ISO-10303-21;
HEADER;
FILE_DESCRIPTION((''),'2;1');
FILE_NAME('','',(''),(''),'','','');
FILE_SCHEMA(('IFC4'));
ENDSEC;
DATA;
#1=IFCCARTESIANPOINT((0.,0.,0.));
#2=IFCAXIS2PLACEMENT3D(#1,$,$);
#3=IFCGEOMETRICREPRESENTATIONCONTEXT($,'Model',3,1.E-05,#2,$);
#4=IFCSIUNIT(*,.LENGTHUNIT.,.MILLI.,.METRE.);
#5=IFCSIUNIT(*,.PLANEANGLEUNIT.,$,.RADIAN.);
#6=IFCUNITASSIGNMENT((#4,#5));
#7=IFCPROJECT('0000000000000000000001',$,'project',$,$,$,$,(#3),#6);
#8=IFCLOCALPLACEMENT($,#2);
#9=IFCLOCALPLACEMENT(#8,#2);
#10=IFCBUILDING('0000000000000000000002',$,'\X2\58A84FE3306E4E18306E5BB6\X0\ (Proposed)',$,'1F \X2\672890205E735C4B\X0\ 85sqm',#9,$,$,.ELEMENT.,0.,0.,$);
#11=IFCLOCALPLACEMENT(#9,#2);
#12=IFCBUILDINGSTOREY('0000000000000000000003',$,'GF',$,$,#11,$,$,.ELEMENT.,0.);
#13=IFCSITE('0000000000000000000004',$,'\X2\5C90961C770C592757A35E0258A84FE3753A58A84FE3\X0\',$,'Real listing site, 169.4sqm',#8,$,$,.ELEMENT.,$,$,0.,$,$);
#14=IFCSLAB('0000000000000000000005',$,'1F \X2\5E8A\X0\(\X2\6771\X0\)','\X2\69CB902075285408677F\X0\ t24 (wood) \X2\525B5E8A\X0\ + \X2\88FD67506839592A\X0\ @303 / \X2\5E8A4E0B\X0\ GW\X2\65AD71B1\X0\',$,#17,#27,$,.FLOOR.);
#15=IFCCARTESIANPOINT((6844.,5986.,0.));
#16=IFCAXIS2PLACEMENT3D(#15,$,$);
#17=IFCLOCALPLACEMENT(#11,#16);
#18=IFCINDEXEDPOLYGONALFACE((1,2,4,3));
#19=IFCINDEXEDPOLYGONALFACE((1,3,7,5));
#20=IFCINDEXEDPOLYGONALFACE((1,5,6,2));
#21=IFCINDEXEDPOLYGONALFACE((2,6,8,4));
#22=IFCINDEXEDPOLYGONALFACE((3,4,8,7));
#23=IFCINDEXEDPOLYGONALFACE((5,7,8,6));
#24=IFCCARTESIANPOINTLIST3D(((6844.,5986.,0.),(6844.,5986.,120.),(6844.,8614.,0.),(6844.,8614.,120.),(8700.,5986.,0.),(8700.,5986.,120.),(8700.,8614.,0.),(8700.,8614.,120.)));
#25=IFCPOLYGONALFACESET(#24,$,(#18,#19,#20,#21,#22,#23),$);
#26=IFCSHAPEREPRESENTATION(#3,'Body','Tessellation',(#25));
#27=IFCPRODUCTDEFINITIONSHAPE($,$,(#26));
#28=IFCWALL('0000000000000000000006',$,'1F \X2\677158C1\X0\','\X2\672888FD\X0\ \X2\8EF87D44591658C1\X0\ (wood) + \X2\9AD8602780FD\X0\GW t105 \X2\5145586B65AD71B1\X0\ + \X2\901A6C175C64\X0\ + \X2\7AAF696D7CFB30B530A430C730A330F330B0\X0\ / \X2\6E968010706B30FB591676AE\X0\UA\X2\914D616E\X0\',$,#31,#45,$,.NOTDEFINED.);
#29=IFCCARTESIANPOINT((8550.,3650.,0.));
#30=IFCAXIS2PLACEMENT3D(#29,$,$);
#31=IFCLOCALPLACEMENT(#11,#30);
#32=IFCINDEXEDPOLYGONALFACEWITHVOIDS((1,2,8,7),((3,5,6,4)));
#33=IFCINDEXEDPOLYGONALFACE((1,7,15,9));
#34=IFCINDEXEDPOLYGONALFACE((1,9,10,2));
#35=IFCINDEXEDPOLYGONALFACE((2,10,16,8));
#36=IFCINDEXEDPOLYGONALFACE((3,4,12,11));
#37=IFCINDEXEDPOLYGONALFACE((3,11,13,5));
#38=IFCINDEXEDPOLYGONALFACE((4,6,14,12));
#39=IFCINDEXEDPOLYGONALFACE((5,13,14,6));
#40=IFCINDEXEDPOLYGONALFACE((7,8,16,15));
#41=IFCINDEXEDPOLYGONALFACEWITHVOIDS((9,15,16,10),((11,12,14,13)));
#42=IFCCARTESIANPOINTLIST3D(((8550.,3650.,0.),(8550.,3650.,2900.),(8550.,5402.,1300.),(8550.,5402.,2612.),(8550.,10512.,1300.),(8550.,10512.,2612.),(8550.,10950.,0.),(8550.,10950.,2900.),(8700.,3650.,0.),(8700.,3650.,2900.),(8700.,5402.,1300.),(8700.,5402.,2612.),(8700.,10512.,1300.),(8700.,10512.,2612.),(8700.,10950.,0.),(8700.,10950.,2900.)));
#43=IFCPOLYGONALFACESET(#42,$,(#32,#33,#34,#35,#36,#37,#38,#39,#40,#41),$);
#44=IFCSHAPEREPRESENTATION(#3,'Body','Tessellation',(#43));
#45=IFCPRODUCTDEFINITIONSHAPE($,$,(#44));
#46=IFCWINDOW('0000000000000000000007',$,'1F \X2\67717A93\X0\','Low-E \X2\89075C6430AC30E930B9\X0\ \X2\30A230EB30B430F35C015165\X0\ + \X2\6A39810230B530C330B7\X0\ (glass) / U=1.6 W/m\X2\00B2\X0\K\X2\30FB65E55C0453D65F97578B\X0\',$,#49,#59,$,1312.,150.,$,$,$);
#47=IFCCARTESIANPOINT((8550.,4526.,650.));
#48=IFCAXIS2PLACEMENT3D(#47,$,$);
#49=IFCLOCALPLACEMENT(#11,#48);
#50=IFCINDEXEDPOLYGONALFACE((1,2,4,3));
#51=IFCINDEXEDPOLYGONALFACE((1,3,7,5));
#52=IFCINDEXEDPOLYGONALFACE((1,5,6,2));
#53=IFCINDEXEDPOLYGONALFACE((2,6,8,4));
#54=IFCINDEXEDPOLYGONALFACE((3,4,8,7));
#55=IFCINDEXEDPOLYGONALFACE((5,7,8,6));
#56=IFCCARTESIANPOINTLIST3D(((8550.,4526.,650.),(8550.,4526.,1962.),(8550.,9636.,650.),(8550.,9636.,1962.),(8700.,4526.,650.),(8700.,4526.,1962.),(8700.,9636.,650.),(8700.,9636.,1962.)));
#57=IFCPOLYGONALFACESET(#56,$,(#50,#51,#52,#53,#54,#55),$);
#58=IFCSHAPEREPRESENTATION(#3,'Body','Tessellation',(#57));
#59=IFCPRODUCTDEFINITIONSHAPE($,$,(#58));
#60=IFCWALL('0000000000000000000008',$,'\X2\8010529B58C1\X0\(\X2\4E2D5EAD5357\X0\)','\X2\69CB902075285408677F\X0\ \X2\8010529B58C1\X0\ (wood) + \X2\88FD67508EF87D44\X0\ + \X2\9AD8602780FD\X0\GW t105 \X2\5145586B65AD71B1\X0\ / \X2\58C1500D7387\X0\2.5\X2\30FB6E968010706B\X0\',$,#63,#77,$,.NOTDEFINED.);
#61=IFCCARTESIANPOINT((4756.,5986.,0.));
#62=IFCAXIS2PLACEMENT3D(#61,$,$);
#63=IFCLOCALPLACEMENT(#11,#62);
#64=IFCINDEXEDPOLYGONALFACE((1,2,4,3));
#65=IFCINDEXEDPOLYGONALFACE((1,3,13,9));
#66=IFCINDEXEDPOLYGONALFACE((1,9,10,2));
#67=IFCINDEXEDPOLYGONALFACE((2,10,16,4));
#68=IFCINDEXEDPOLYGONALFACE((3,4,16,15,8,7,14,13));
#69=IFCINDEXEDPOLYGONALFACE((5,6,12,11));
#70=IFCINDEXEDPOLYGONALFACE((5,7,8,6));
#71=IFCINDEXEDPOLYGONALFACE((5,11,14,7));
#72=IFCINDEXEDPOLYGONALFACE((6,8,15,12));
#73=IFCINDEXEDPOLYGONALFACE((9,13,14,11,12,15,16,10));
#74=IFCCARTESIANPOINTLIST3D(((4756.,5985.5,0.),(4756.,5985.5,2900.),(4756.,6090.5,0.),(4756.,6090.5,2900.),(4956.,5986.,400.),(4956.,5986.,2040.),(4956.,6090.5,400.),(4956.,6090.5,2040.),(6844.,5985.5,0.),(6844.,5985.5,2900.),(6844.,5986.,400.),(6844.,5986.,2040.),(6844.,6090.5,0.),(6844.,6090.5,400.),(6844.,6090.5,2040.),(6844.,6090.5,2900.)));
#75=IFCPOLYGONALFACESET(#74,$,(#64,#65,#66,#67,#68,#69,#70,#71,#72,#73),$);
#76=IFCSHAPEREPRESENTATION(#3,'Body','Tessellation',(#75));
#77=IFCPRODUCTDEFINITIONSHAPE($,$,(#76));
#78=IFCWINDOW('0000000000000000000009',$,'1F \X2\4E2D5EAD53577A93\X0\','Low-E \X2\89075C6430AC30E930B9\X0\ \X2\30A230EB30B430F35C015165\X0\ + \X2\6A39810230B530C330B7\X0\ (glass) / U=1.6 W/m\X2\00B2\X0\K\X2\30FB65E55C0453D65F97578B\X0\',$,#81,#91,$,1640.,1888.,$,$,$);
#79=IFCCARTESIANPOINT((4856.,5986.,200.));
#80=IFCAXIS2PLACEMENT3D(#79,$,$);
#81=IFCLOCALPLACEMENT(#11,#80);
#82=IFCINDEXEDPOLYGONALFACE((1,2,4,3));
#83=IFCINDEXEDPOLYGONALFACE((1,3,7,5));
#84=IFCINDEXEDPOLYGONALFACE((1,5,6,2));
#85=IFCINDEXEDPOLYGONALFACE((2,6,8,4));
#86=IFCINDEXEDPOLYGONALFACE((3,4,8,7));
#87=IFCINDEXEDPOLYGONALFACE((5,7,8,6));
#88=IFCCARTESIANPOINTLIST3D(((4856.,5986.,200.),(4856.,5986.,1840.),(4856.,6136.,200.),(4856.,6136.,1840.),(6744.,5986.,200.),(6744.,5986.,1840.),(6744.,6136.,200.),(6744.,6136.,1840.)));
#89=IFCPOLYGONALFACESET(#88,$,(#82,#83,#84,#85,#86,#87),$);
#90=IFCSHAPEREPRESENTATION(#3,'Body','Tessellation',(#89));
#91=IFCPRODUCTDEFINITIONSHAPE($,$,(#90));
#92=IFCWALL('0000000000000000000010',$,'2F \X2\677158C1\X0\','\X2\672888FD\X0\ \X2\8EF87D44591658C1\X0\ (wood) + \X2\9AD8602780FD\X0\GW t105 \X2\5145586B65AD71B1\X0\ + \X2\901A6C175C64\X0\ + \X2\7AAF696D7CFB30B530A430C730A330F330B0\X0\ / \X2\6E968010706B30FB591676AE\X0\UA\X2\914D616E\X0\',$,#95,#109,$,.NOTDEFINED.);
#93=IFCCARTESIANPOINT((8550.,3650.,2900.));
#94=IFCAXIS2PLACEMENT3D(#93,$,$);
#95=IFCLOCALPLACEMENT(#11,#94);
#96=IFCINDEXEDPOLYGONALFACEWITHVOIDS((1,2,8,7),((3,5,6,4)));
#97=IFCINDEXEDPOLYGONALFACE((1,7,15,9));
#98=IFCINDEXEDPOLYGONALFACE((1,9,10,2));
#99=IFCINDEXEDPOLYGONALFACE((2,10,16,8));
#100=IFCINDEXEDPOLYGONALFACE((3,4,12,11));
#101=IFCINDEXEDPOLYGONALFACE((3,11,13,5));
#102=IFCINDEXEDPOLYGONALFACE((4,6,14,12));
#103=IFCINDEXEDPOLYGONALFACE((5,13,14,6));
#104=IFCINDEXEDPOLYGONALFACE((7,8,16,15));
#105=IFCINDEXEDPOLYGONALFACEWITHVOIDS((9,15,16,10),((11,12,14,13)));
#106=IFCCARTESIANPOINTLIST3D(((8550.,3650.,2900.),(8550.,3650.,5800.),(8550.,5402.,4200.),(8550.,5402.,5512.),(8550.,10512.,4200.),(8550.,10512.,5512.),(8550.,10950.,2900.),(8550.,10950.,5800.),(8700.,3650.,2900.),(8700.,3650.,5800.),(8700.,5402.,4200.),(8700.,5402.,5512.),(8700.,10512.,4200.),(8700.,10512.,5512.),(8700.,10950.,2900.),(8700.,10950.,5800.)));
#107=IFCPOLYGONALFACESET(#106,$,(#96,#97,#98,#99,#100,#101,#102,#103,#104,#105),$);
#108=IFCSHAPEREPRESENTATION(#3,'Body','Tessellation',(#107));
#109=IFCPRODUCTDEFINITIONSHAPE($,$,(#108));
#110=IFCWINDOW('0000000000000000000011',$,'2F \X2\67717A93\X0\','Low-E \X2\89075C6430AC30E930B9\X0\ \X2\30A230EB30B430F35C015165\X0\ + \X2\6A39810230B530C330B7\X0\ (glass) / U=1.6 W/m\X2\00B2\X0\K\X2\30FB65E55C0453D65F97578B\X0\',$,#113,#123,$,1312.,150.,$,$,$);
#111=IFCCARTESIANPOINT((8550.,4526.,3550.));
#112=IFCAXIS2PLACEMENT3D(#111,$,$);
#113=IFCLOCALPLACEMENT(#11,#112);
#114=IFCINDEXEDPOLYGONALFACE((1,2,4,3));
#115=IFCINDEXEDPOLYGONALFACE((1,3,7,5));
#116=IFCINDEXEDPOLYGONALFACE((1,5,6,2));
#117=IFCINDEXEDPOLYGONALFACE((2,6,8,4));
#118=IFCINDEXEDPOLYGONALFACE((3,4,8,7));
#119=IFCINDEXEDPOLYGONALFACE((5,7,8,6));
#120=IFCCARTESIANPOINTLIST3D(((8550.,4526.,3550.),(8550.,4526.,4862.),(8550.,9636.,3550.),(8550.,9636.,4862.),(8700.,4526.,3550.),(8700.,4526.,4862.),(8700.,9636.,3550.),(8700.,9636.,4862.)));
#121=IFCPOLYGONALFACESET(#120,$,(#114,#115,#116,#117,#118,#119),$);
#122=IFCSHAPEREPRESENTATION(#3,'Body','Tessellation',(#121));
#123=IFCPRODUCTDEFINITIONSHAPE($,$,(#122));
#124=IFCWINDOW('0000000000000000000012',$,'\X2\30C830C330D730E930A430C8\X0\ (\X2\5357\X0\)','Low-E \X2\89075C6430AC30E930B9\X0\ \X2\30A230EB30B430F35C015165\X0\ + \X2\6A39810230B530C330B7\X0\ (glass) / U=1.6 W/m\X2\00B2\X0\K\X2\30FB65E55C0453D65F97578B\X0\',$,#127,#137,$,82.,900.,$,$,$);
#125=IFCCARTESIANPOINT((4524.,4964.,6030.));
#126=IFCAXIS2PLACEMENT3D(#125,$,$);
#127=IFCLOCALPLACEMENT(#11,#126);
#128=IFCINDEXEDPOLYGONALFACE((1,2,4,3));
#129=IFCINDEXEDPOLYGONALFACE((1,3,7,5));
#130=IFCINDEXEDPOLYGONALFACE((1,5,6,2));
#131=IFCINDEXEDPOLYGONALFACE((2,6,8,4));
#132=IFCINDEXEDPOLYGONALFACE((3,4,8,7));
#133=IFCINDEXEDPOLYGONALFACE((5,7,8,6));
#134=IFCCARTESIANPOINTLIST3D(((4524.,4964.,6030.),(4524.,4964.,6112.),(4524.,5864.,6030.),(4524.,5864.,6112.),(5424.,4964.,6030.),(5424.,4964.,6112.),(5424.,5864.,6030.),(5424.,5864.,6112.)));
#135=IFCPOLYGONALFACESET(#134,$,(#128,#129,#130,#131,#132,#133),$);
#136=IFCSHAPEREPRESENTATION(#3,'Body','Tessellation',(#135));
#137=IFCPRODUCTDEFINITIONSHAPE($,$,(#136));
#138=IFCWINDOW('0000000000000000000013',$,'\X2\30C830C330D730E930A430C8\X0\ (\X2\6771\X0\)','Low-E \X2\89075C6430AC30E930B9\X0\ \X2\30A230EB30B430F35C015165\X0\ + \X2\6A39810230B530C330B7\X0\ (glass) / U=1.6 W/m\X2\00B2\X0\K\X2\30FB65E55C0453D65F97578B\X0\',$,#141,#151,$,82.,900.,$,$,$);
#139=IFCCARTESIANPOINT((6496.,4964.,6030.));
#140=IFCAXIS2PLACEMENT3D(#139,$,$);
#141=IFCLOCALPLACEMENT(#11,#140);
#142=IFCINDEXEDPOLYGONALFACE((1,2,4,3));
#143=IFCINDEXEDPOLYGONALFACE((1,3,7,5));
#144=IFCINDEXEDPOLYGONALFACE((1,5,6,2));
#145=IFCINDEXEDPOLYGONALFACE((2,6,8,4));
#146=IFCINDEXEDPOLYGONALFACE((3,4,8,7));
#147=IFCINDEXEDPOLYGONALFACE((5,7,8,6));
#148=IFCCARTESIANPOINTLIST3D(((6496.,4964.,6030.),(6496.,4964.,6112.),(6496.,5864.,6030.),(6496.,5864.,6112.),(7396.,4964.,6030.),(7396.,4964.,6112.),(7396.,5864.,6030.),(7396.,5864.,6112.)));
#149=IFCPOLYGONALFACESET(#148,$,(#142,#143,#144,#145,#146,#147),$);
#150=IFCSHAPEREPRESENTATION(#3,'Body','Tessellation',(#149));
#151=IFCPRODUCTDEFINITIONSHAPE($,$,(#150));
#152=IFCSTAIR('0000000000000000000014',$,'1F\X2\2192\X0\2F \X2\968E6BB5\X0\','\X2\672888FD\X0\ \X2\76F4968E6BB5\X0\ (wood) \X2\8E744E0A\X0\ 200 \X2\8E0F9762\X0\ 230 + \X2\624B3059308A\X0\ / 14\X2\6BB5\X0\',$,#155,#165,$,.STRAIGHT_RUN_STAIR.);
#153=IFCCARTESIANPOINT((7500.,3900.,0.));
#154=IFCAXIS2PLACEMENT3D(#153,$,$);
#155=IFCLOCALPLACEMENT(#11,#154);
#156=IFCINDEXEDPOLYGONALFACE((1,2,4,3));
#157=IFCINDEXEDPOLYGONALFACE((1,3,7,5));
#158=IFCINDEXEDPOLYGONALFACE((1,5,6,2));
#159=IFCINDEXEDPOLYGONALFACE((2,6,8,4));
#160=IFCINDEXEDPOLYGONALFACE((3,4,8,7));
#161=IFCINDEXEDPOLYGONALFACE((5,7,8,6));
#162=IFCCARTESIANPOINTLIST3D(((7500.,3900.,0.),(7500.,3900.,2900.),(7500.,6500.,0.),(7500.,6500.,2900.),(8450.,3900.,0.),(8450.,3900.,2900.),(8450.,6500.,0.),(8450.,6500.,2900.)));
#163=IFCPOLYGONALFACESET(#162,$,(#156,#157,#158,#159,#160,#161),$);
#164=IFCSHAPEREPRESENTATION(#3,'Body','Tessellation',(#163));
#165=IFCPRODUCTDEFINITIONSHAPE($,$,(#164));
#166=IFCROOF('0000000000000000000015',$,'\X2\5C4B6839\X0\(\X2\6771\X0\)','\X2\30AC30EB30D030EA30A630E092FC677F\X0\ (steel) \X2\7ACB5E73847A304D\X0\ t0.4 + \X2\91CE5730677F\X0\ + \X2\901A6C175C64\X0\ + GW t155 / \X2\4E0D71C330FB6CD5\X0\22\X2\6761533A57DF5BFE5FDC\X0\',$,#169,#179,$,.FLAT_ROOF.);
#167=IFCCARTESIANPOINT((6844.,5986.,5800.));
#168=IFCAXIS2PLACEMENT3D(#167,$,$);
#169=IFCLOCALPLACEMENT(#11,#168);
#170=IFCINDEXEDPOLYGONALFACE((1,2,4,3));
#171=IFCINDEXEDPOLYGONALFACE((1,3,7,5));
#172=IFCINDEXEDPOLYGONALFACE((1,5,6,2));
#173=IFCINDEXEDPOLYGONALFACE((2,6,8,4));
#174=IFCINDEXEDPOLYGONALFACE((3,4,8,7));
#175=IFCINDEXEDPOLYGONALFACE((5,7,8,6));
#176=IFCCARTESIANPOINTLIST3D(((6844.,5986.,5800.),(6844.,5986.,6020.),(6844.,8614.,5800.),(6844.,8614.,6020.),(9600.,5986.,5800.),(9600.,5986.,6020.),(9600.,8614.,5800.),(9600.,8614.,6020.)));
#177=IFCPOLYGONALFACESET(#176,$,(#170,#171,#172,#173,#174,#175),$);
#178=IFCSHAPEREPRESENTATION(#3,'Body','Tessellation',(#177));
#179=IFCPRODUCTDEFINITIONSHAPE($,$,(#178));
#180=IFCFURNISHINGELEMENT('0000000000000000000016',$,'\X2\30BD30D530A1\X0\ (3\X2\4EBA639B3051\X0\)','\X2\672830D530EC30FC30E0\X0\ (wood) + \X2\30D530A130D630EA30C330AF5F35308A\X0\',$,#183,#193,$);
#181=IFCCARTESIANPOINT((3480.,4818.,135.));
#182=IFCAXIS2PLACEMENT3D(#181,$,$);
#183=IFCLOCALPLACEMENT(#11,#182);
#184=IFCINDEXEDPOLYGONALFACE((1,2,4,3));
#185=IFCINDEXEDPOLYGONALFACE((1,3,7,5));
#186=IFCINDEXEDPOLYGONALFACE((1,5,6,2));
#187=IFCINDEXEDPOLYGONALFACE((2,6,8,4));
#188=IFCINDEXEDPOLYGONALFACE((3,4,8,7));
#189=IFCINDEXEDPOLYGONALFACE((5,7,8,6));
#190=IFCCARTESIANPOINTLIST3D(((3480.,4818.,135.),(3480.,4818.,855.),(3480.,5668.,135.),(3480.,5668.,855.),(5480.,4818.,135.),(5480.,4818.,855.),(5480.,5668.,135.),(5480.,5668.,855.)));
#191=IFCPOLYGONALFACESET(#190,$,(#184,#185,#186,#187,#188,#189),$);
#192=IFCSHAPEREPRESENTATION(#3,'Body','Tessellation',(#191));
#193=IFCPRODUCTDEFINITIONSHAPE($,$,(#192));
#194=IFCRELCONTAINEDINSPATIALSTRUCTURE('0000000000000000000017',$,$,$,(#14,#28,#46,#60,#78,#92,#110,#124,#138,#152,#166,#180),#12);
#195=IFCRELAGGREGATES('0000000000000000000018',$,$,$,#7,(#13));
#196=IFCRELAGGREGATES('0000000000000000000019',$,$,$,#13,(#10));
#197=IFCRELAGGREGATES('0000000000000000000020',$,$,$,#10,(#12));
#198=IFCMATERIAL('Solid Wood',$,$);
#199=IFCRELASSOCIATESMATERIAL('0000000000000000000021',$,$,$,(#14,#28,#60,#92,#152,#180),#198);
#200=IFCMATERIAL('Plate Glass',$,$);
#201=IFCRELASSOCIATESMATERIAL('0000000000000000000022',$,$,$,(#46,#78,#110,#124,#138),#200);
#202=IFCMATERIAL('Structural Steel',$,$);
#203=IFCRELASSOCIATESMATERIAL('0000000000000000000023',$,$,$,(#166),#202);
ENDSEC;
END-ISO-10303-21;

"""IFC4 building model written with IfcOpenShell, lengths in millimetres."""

from ifc_helpers import new_model, si_unit, frame, frame_2d, origin, place, context, project, spatial, rectangle, extrude, material, element, fill, save


model = new_model("IFC4")

# Units and contexts
model_context = context("Model", 3, precision=1e-05, world=origin())
ifc_project = project(units=[si_unit("LENGTHUNIT", "METRE", prefix="MILLI"), si_unit("PLANEANGLEUNIT", "RADIAN")], contexts=[model_context])

# Site, building, storey
site_placement = place(None, origin())
site = spatial("IfcSite", under=ifc_project, at=site_placement, Name="岐阜県大垣市墨俣町墨俣", ObjectType="Real listing site, 169.4sqm", CompositionType="ELEMENT", RefElevation=0.0)
building_placement = place(site_placement, origin())
building = spatial("IfcBuilding", under=site, at=building_placement, Name="墨俣の丘の家 (Proposed)", ObjectType="1F 木造平屋 85sqm", CompositionType="ELEMENT", ElevationOfRefHeight=0.0, ElevationOfTerrain=0.0)
storey_placement = place(building_placement, origin())
storey = spatial("IfcBuildingStorey", under=building, at=storey_placement, Name="GF", CompositionType="ELEMENT", Elevation=0.0)

# Slab
ifc_material_1 = material(Name="Solid Wood")
slab_placement = place(storey_placement, frame((6844.0, 5986.0, 0.0)))
element("IfcSlab", 1, at=slab_placement, inside=storey, material=ifc_material_1, Name="1F 床(東)", Description="構造用合板 t24 (wood) 剛床 + 製材根太 @303 / 床下 GW断熱", PredefinedType="FLOOR", context=model_context, shape_type="SweptSolid", body=[
    extrude(rectangle(XDim=1856.0, YDim=2628.0, at=frame_2d((928.0, 1314.0))), frame((6844.0, 5986.0, 0.0)), (0.0, 0.0, 1.0), 120.0),
])

# Walls, openings, windows
wall_1_placement = place(storey_placement, frame((8550.0, 3650.0, 0.0)))
wall_1 = element("IfcWall", 2, at=wall_1_placement, inside=storey, material=ifc_material_1, Name="1F 東壁", Description="木製 軸組外壁 (wood) + 高性能GW t105 充填断熱 + 通気層 + 窯業系サイディング / 準耐火・外皮UA配慮", PredefinedType="NOTDEFINED", context=model_context, shape_type="SweptSolid", body=[
    extrude(rectangle(XDim=150.0, YDim=7300.0, at=frame_2d((75.0, 3650.0))), frame((8550.0, 3650.0, 0.0)), (0.0, 0.0, 1.0), 2900.0),
])
opening_1_placement = place(storey_placement, frame((8550.0, 4526.0, 650.0)))
opening_1 = element("IfcOpeningElement", 3, at=opening_1_placement, cuts=wall_1, PredefinedType="NOTDEFINED", context=model_context, shape_type="SweptSolid", body=[
    extrude(rectangle(XDim=150.0, YDim=5110.0, at=frame_2d((75.0, 2555.0))), frame((8550.0, 4526.0, 650.0)), (0.0, 0.0, 1.0), 1312.0),
])
ifc_material_2 = material(Name="Plate Glass")
window_1_placement = place(storey_placement, frame((8550.0, 4526.0, 650.0)))
window_1 = element("IfcWindow", 4, at=window_1_placement, inside=storey, material=ifc_material_2, Name="1F 東窓", Description="Low-E 複層ガラス アルゴン封入 + 樹脂サッシ (glass) / U=1.6 W/m²K・日射取得型", OverallHeight=1312.0, OverallWidth=150.0, context=model_context, shape_type="SweptSolid", body=[
    extrude(rectangle(XDim=150.0, YDim=5110.0, at=frame_2d((75.0, 2555.0))), frame((8550.0, 4526.0, 650.0)), (0.0, 0.0, 1.0), 1312.0),
])
fill(opening_1, window_1)
wall_2_placement = place(storey_placement, frame((4756.0, 5986.0, 0.0)))
wall_2 = element("IfcWall", 5, at=wall_2_placement, inside=storey, material=ifc_material_1, Name="耐力壁(中庭南)", Description="構造用合板 耐力壁 (wood) + 製材軸組 + 高性能GW t105 充填断熱 / 壁倍率2.5・準耐火", PredefinedType="NOTDEFINED", context=model_context, shape_type="SweptSolid", body=[
    extrude(rectangle(XDim=2088.0, YDim=105.0, at=frame_2d((1044.0, 52.0))), frame((4756.0, 5986.0, 0.0)), (0.0, 0.0, 1.0), 2900.0),
])
opening_2_placement = place(storey_placement, frame((4856.0, 5986.0, 200.0)))
opening_2 = element("IfcOpeningElement", 6, at=opening_2_placement, cuts=wall_2, PredefinedType="NOTDEFINED", context=model_context, shape_type="SweptSolid", body=[
    extrude(rectangle(XDim=1888.0, YDim=150.0, at=frame_2d((944.0, 75.0))), frame((4856.0, 5986.0, 200.0)), (0.0, 0.0, 1.0), 1640.0),
])
window_2_placement = place(storey_placement, frame((4856.0, 5986.0, 200.0)))
window_2 = element("IfcWindow", 7, at=window_2_placement, inside=storey, material=ifc_material_2, Name="1F 中庭南窓", Description="Low-E 複層ガラス アルゴン封入 + 樹脂サッシ (glass) / U=1.6 W/m²K・日射取得型", OverallHeight=1640.0, OverallWidth=1888.0, context=model_context, shape_type="SweptSolid", body=[
    extrude(rectangle(XDim=1888.0, YDim=150.0, at=frame_2d((944.0, 75.0))), frame((4856.0, 5986.0, 200.0)), (0.0, 0.0, 1.0), 1640.0),
])
fill(opening_2, window_2)

# Wall, opening, window
wall_3_placement = place(storey_placement, frame((8550.0, 3650.0, 2900.0)))
wall_3 = element("IfcWall", 8, at=wall_3_placement, inside=storey, material=ifc_material_1, Name="2F 東壁", Description="木製 軸組外壁 (wood) + 高性能GW t105 充填断熱 + 通気層 + 窯業系サイディング / 準耐火・外皮UA配慮", PredefinedType="NOTDEFINED", context=model_context, shape_type="SweptSolid", body=[
    extrude(rectangle(XDim=150.0, YDim=7300.0, at=frame_2d((75.0, 3650.0))), frame((8550.0, 3650.0, 2900.0)), (0.0, 0.0, 1.0), 2900.0),
])
opening_3_placement = place(storey_placement, frame((8550.0, 4526.0, 3550.0)))
opening_3 = element("IfcOpeningElement", 9, at=opening_3_placement, cuts=wall_3, PredefinedType="NOTDEFINED", context=model_context, shape_type="SweptSolid", body=[
    extrude(rectangle(XDim=150.0, YDim=5110.0, at=frame_2d((75.0, 2555.0))), frame((8550.0, 4526.0, 3550.0)), (0.0, 0.0, 1.0), 1312.0),
])
window_3_placement = place(storey_placement, frame((8550.0, 4526.0, 3550.0)))
window_3 = element("IfcWindow", 10, at=window_3_placement, inside=storey, material=ifc_material_2, Name="2F 東窓", Description="Low-E 複層ガラス アルゴン封入 + 樹脂サッシ (glass) / U=1.6 W/m²K・日射取得型", OverallHeight=1312.0, OverallWidth=150.0, context=model_context, shape_type="SweptSolid", body=[
    extrude(rectangle(XDim=150.0, YDim=5110.0, at=frame_2d((75.0, 2555.0))), frame((8550.0, 4526.0, 3550.0)), (0.0, 0.0, 1.0), 1312.0),
])
fill(opening_3, window_3)

# Windows
window_4_placement = place(storey_placement, frame((4524.0, 4964.0, 6030.0)))
element("IfcWindow", 11, at=window_4_placement, inside=storey, material=ifc_material_2, Name="トップライト (南)", Description="Low-E 複層ガラス アルゴン封入 + 樹脂サッシ (glass) / U=1.6 W/m²K・日射取得型", OverallHeight=82.0, OverallWidth=900.0, context=model_context, shape_type="SweptSolid", body=[
    extrude(rectangle(XDim=900.0, YDim=900.0, at=frame_2d((450.0, 450.0))), frame((4524.0, 4964.0, 6030.0)), (0.0, 0.0, 1.0), 82.0),
])
window_5_placement = place(storey_placement, frame((6496.0, 4964.0, 6030.0)))
element("IfcWindow", 12, at=window_5_placement, inside=storey, material=ifc_material_2, Name="トップライト (東)", Description="Low-E 複層ガラス アルゴン封入 + 樹脂サッシ (glass) / U=1.6 W/m²K・日射取得型", OverallHeight=82.0, OverallWidth=900.0, context=model_context, shape_type="SweptSolid", body=[
    extrude(rectangle(XDim=900.0, YDim=900.0, at=frame_2d((450.0, 450.0))), frame((6496.0, 4964.0, 6030.0)), (0.0, 0.0, 1.0), 82.0),
])

# Stair
stair_placement = place(storey_placement, frame((7500.0, 3900.0, 0.0)))
element("IfcStair", 13, at=stair_placement, inside=storey, material=ifc_material_1, Name="1F→2F 階段", Description="木製 直階段 (wood) 蹴上 200 踏面 230 + 手すり / 14段", PredefinedType="STRAIGHT_RUN_STAIR", context=model_context, shape_type="SweptSolid", body=[
    extrude(rectangle(XDim=950.0, YDim=2600.0, at=frame_2d((475.0, 1300.0))), frame((7500.0, 3900.0, 0.0)), (0.0, 0.0, 1.0), 2900.0),
])

# Roof
ifc_material_3 = material(Name="Structural Steel")
roof_placement = place(storey_placement, frame((6844.0, 5986.0, 5800.0)))
element("IfcRoof", 14, at=roof_placement, inside=storey, material=ifc_material_3, Name="屋根(東)", Description="ガルバリウム鋼板 (steel) 立平葺き t0.4 + 野地板 + 通気層 + GW t155 / 不燃・法22条区域対応", PredefinedType="FLAT_ROOF", context=model_context, shape_type="SweptSolid", body=[
    extrude(rectangle(XDim=2756.0, YDim=2628.0, at=frame_2d((1378.0, 1314.0))), frame((6844.0, 5986.0, 5800.0)), (0.0, 0.0, 1.0), 220.0),
])

# Furnishing element
furnishing_1_placement = place(storey_placement, frame((3480.0, 4818.0, 135.0)))
element("IfcFurnishingElement", 15, at=furnishing_1_placement, inside=storey, material=ifc_material_1, Name="ソファ (3人掛け)", Description="木フレーム (wood) + ファブリック張り", context=model_context, shape_type="SweptSolid", body=[
    extrude(rectangle(XDim=2000.0, YDim=850.0, at=frame_2d((1000.0, 425.0))), frame((3480.0, 4818.0, 135.0)), (0.0, 0.0, 1.0), 720.0),
])

save(model, "model.ifc")
